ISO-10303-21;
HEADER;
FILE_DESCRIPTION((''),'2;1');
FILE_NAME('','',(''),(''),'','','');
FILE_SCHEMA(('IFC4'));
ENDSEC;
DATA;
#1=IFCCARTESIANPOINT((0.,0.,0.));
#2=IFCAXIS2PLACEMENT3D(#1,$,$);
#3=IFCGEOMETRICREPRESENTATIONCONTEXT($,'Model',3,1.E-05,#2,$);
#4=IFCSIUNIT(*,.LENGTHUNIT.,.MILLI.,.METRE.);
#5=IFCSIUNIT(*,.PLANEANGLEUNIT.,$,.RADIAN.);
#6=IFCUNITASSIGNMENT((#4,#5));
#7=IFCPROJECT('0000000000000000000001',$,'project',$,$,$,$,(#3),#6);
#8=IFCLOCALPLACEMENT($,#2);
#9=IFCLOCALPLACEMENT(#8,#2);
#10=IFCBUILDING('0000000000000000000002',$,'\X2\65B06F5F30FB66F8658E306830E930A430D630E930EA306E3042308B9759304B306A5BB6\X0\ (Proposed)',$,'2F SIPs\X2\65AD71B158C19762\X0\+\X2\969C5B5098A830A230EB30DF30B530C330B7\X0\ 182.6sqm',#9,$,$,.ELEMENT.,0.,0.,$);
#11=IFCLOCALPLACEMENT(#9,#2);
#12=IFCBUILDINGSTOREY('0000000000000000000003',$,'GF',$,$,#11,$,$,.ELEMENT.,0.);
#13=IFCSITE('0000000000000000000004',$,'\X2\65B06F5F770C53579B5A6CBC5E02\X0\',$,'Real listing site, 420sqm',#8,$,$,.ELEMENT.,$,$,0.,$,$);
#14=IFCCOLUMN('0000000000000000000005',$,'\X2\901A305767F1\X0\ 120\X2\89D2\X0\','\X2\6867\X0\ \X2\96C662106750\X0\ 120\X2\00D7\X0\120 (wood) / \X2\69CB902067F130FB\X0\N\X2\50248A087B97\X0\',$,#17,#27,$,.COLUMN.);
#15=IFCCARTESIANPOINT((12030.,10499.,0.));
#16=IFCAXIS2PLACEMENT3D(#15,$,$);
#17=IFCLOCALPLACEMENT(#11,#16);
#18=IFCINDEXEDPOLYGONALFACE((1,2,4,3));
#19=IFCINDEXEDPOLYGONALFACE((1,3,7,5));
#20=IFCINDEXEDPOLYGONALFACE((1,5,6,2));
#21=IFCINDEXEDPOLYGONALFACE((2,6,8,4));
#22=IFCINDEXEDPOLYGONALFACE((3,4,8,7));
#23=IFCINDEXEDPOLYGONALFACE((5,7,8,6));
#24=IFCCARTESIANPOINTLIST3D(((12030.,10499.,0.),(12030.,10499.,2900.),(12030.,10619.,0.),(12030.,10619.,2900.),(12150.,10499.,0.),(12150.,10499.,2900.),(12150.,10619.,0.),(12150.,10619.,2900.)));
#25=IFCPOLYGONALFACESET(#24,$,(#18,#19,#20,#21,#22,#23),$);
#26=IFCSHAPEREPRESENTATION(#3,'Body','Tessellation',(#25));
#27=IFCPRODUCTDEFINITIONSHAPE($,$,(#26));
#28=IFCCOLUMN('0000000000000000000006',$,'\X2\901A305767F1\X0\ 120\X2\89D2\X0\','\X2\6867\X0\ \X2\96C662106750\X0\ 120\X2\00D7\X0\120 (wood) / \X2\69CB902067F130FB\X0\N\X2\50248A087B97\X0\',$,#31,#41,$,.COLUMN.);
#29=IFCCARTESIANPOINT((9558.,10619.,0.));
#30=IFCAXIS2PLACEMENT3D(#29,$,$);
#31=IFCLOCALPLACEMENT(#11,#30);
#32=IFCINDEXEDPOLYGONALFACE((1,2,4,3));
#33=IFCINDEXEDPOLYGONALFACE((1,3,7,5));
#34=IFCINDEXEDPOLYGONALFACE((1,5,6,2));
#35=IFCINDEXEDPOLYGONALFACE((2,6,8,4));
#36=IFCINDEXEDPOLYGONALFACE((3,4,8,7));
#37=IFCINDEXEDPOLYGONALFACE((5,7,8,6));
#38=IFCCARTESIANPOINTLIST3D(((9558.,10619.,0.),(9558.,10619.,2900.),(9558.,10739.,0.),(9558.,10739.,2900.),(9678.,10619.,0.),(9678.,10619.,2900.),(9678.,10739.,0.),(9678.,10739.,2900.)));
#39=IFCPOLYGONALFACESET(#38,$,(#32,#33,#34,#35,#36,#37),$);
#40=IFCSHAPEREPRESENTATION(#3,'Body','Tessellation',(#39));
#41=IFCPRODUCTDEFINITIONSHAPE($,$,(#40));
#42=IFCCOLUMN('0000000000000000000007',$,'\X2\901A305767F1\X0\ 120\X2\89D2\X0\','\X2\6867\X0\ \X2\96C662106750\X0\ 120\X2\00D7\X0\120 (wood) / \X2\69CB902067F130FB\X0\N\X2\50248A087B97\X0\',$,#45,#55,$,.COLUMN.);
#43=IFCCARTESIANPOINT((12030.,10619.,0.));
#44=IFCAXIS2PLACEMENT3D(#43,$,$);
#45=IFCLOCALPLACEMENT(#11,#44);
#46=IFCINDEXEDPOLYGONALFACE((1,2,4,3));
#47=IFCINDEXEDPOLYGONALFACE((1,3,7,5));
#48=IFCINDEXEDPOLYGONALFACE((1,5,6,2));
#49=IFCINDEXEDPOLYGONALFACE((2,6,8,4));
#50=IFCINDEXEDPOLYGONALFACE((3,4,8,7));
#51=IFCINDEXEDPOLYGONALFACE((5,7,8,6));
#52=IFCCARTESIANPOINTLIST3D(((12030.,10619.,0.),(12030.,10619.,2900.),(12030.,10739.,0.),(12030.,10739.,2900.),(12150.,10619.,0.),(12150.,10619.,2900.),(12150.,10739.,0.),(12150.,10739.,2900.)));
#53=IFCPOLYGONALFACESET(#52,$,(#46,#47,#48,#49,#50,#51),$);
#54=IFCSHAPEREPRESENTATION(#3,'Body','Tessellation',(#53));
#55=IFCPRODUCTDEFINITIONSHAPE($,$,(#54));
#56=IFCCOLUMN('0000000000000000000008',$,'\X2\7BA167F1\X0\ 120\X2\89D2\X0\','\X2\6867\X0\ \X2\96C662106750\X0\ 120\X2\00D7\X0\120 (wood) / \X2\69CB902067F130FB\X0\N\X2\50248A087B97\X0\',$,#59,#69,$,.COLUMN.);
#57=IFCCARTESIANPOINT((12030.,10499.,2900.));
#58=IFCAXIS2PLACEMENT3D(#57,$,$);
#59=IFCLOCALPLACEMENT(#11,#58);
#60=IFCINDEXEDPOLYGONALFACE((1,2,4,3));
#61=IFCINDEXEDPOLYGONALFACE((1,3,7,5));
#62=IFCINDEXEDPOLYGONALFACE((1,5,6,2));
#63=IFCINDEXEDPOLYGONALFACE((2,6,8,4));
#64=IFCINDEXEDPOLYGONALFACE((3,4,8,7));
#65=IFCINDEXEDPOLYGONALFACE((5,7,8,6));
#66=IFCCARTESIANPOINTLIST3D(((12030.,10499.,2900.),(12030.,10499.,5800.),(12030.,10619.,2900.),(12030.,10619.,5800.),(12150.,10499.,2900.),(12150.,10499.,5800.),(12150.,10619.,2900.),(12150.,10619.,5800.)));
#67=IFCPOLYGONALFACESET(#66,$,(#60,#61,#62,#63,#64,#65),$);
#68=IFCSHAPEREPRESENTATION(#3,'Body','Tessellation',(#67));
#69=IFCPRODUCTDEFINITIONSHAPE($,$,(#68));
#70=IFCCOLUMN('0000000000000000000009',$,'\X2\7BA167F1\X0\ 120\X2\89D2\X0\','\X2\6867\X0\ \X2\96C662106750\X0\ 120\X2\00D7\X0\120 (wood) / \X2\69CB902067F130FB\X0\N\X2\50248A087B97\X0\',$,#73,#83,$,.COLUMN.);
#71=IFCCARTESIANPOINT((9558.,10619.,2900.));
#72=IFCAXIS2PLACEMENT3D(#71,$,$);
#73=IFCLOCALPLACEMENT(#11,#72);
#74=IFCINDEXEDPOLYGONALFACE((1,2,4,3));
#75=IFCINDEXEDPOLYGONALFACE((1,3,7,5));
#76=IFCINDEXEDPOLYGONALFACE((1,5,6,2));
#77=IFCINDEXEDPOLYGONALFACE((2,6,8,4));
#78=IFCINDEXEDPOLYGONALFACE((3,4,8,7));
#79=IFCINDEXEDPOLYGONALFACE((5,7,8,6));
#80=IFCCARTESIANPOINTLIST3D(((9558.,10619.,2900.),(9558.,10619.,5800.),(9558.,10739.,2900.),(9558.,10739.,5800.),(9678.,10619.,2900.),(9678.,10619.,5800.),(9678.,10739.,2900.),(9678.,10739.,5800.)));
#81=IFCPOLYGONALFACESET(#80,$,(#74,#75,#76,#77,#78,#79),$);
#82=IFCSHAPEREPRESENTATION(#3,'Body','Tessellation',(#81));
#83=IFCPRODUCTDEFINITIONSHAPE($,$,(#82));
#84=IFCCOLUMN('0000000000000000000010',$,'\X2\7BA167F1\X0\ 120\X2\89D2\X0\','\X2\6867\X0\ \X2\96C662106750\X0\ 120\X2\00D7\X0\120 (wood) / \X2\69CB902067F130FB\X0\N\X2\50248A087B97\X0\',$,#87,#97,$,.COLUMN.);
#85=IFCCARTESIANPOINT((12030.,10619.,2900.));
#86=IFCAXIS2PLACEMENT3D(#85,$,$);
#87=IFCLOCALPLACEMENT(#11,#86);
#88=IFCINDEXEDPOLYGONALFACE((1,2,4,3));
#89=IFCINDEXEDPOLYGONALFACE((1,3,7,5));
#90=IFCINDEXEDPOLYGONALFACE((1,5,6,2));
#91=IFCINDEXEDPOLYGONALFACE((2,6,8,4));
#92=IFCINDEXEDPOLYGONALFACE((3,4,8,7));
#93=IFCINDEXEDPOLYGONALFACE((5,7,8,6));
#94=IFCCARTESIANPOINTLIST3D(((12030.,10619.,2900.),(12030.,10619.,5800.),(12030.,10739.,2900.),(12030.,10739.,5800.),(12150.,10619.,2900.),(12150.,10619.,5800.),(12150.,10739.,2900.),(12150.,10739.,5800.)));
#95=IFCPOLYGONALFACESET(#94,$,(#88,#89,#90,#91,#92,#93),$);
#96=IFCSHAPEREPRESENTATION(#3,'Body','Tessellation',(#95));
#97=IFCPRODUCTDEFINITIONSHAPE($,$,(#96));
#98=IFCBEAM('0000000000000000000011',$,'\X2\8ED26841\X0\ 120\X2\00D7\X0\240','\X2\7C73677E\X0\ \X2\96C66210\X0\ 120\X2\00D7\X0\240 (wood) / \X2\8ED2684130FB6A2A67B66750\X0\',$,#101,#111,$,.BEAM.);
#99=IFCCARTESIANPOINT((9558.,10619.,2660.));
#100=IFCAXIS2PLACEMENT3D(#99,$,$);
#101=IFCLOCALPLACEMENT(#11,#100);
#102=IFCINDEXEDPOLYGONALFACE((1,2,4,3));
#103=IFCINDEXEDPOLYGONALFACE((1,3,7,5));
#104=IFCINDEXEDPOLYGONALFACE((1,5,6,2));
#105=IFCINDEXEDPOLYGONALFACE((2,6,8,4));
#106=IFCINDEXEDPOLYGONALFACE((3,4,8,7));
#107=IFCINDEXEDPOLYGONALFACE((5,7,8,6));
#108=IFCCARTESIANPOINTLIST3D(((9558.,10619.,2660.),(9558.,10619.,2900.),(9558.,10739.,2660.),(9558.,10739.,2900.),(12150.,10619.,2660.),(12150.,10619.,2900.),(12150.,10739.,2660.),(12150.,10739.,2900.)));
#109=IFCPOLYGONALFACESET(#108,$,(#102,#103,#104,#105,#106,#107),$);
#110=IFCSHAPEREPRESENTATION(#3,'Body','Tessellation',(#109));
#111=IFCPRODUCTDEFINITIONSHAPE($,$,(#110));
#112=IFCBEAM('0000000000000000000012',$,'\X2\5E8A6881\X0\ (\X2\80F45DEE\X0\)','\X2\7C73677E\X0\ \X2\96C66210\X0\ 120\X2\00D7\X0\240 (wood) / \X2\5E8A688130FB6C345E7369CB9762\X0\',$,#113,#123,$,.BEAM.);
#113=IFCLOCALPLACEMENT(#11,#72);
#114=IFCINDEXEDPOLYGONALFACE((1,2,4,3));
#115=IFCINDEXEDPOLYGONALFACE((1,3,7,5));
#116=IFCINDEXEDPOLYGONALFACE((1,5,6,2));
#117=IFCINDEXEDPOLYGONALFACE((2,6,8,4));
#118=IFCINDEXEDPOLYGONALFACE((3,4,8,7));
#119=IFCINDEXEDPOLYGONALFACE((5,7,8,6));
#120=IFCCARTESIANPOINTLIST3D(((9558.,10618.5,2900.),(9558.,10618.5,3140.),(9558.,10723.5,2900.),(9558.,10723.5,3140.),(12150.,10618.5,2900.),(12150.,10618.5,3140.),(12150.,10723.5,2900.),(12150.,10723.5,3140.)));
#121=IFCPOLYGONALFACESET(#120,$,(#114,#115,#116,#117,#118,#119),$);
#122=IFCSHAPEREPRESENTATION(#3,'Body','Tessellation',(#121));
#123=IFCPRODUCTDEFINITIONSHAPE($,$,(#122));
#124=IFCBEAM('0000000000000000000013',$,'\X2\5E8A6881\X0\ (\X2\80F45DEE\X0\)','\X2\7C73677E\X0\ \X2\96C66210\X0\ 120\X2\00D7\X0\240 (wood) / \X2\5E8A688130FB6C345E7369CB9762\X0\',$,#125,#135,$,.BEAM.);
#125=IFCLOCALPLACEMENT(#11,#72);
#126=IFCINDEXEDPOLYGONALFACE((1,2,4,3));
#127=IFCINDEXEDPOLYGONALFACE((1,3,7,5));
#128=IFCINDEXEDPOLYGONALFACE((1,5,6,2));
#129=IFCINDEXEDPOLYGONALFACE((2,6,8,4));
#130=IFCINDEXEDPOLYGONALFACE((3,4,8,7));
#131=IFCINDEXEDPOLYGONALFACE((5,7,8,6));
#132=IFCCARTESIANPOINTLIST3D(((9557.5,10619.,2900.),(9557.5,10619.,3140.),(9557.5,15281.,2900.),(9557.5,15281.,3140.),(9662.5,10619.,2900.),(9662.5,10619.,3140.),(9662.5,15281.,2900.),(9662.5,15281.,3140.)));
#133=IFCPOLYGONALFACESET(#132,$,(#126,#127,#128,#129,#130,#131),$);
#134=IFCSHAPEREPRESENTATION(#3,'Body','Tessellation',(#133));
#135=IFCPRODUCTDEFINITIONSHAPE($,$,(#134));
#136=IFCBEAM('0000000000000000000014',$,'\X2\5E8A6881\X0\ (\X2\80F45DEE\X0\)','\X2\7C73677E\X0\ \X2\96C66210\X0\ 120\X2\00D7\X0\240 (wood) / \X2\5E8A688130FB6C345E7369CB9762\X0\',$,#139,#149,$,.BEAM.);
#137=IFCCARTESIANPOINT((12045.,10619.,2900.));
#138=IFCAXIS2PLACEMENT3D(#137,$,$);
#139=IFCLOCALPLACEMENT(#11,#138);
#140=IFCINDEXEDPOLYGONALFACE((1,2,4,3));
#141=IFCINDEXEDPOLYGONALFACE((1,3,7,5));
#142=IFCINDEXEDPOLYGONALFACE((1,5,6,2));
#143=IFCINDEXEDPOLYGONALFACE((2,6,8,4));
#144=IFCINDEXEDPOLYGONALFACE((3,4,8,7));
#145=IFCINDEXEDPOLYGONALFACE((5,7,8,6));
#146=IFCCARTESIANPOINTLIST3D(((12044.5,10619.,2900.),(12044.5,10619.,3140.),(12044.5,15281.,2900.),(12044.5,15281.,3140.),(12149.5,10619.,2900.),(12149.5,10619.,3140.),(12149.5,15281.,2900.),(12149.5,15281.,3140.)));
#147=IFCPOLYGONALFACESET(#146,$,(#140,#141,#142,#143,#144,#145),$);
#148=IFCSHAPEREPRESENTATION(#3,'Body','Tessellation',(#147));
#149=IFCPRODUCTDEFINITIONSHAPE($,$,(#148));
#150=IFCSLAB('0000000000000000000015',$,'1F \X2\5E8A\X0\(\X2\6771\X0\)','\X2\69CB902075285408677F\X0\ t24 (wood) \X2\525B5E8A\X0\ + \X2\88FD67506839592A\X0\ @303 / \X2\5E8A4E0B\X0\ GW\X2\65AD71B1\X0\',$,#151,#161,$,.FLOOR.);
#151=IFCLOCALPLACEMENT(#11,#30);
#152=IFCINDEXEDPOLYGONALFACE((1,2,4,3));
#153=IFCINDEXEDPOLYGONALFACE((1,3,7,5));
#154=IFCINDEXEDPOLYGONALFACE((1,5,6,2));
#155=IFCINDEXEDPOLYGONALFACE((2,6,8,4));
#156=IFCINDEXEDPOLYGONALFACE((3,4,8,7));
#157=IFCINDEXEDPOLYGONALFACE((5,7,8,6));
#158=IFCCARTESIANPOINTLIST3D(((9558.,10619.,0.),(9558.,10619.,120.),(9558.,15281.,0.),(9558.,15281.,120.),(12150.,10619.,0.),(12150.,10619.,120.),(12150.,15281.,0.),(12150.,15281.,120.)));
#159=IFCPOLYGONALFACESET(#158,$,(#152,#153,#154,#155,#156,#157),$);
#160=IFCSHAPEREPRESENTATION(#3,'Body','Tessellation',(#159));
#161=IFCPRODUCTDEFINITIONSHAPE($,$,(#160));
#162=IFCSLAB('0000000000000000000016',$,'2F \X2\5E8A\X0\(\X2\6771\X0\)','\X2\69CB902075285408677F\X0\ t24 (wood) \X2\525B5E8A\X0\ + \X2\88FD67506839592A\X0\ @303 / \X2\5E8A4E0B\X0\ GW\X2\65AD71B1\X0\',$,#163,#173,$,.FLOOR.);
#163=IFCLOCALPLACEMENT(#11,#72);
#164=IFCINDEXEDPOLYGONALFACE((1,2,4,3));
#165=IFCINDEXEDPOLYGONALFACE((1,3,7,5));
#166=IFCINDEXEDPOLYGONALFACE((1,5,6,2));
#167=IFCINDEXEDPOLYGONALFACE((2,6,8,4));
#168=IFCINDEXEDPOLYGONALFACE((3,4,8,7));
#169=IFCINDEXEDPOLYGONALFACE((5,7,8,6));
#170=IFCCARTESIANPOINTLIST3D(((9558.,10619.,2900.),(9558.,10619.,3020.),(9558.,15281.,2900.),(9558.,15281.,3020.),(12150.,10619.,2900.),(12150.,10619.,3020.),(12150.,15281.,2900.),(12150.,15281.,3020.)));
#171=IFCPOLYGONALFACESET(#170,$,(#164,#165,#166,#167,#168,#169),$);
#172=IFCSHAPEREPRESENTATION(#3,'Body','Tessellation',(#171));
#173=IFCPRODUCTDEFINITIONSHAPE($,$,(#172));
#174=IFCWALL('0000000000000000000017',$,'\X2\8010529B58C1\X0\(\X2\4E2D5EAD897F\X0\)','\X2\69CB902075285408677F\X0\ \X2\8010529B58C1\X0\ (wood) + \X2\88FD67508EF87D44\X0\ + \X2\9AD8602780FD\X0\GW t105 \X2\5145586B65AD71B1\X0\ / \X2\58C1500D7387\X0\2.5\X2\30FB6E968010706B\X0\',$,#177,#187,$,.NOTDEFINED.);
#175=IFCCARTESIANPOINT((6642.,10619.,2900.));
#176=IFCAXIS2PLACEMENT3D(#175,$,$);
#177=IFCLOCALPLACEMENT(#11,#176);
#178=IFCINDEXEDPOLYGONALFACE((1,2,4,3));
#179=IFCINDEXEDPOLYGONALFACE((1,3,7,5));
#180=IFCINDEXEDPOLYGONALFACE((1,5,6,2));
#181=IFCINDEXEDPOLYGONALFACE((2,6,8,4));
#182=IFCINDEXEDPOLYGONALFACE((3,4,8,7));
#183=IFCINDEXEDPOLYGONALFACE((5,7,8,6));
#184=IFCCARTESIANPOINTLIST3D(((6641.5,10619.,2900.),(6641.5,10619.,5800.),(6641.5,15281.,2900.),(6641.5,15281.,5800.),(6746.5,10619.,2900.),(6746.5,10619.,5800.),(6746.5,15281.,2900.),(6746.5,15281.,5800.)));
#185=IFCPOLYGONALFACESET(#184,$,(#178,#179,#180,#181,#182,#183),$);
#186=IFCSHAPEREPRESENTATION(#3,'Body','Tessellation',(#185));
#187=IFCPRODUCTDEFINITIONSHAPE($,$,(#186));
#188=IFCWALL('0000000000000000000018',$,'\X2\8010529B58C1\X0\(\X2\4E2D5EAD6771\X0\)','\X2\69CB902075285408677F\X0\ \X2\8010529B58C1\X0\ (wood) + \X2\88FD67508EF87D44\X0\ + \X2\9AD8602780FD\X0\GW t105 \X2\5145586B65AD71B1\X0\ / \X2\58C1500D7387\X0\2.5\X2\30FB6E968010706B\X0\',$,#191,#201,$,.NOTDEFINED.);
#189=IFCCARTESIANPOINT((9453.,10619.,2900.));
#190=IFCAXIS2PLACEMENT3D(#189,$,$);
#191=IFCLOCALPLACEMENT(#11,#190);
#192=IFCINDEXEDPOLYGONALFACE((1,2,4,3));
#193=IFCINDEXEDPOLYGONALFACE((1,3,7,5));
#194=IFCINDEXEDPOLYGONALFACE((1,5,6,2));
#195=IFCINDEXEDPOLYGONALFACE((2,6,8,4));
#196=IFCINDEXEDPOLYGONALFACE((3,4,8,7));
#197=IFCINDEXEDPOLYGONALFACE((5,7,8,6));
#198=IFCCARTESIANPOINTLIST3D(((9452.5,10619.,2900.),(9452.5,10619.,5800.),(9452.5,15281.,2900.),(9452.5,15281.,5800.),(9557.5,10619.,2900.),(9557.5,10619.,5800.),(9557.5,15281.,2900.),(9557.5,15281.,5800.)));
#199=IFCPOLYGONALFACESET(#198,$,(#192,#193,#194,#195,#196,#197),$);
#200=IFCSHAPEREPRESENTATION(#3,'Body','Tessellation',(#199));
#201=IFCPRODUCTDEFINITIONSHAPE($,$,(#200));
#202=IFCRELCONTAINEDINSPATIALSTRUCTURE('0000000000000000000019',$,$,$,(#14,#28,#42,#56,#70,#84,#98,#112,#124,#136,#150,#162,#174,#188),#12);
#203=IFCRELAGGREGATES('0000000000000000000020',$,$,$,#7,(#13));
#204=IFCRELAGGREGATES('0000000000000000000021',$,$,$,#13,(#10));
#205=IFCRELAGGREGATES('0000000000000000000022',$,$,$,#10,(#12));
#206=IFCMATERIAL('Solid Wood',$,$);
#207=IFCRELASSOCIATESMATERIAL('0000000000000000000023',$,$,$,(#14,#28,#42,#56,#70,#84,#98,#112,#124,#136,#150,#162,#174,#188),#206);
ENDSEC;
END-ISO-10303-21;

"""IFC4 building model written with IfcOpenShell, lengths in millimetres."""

from ifc_helpers import new_model, si_unit, frame, frame_2d, origin, place, context, project, spatial, rectangle, extrude, material, element, save


model = new_model("IFC4")

# Units and contexts
model_context = context("Model", 3, precision=1e-05, world=origin())
ifc_project = project(units=[si_unit("LENGTHUNIT", "METRE", prefix="MILLI"), si_unit("PLANEANGLEUNIT", "RADIAN")], contexts=[model_context])

# Site, building, storey
site_placement = place(None, origin())
site = spatial("IfcSite", under=ifc_project, at=site_placement, Name="新潟県南魚沼市", ObjectType="Real listing site, 420sqm", CompositionType="ELEMENT", RefElevation=0.0)
building_placement = place(site_placement, origin())
building = spatial("IfcBuilding", under=site, at=building_placement, Name="新潟・書斎とライブラリのある静かな家 (Proposed)", ObjectType="2F SIPs断熱壁面+障子風アルミサッシ 182.6sqm", CompositionType="ELEMENT", ElevationOfRefHeight=0.0, ElevationOfTerrain=0.0)
storey_placement = place(building_placement, origin())
storey = spatial("IfcBuildingStorey", under=building, at=storey_placement, Name="GF", CompositionType="ELEMENT", Elevation=0.0)

# Columns
ifc_material_1 = material(Name="Solid Wood")
column_1_placement = place(storey_placement, frame((12030.0, 10499.0, 0.0)))
element("IfcColumn", 1, at=column_1_placement, inside=storey, material=ifc_material_1, Name="通し柱 120角", Description="桧 集成材 120×120 (wood) / 構造柱・N値計算", PredefinedType="COLUMN", context=model_context, shape_type="SweptSolid", body=[
    extrude(rectangle(XDim=120.0, YDim=120.0, at=frame_2d((60.0, 60.0))), frame((12030.0, 10499.0, 0.0)), (0.0, 0.0, 1.0), 2900.0),
])
column_2_placement = place(storey_placement, frame((9558.0, 10619.0, 0.0)))
element("IfcColumn", 2, at=column_2_placement, inside=storey, material=ifc_material_1, Name="通し柱 120角", Description="桧 集成材 120×120 (wood) / 構造柱・N値計算", PredefinedType="COLUMN", context=model_context, shape_type="SweptSolid", body=[
    extrude(rectangle(XDim=120.0, YDim=120.0, at=frame_2d((60.0, 60.0))), frame((9558.0, 10619.0, 0.0)), (0.0, 0.0, 1.0), 2900.0),
])
column_3_placement = place(storey_placement, frame((12030.0, 10619.0, 0.0)))
element("IfcColumn", 3, at=column_3_placement, inside=storey, material=ifc_material_1, Name="通し柱 120角", Description="桧 集成材 120×120 (wood) / 構造柱・N値計算", PredefinedType="COLUMN", context=model_context, shape_type="SweptSolid", body=[
    extrude(rectangle(XDim=120.0, YDim=120.0, at=frame_2d((60.0, 60.0))), frame((12030.0, 10619.0, 0.0)), (0.0, 0.0, 1.0), 2900.0),
])
column_4_placement = place(storey_placement, frame((12030.0, 10499.0, 2900.0)))
element("IfcColumn", 4, at=column_4_placement, inside=storey, material=ifc_material_1, Name="管柱 120角", Description="桧 集成材 120×120 (wood) / 構造柱・N値計算", PredefinedType="COLUMN", context=model_context, shape_type="SweptSolid", body=[
    extrude(rectangle(XDim=120.0, YDim=120.0, at=frame_2d((60.0, 60.0))), frame((12030.0, 10499.0, 2900.0)), (0.0, 0.0, 1.0), 2900.0),
])
column_5_placement = place(storey_placement, frame((9558.0, 10619.0, 2900.0)))
element("IfcColumn", 5, at=column_5_placement, inside=storey, material=ifc_material_1, Name="管柱 120角", Description="桧 集成材 120×120 (wood) / 構造柱・N値計算", PredefinedType="COLUMN", context=model_context, shape_type="SweptSolid", body=[
    extrude(rectangle(XDim=120.0, YDim=120.0, at=frame_2d((60.0, 60.0))), frame((9558.0, 10619.0, 2900.0)), (0.0, 0.0, 1.0), 2900.0),
])
column_6_placement = place(storey_placement, frame((12030.0, 10619.0, 2900.0)))
element("IfcColumn", 6, at=column_6_placement, inside=storey, material=ifc_material_1, Name="管柱 120角", Description="桧 集成材 120×120 (wood) / 構造柱・N値計算", PredefinedType="COLUMN", context=model_context, shape_type="SweptSolid", body=[
    extrude(rectangle(XDim=120.0, YDim=120.0, at=frame_2d((60.0, 60.0))), frame((12030.0, 10619.0, 2900.0)), (0.0, 0.0, 1.0), 2900.0),
])

# Beams
beam_1_placement = place(storey_placement, frame((9558.0, 10619.0, 2660.0)))
element("IfcBeam", 7, at=beam_1_placement, inside=storey, material=ifc_material_1, Name="軒桁 120×240", Description="米松 集成 120×240 (wood) / 軒桁・横架材", PredefinedType="BEAM", context=model_context, shape_type="SweptSolid", body=[
    extrude(rectangle(XDim=2592.0, YDim=120.0, at=frame_2d((1296.0, 60.0))), frame((9558.0, 10619.0, 2660.0)), (0.0, 0.0, 1.0), 240.0),
])
beam_2_placement = place(storey_placement, frame((9558.0, 10619.0, 2900.0)))
element("IfcBeam", 8, at=beam_2_placement, inside=storey, material=ifc_material_1, Name="床梁 (胴差)", Description="米松 集成 120×240 (wood) / 床梁・水平構面", PredefinedType="BEAM", context=model_context, shape_type="SweptSolid", body=[
    extrude(rectangle(XDim=2592.0, YDim=105.0, at=frame_2d((1296.0, 52.0))), frame((9558.0, 10619.0, 2900.0)), (0.0, 0.0, 1.0), 240.0),
])
beam_3_placement = place(storey_placement, frame((9558.0, 10619.0, 2900.0)))
element("IfcBeam", 9, at=beam_3_placement, inside=storey, material=ifc_material_1, Name="床梁 (胴差)", Description="米松 集成 120×240 (wood) / 床梁・水平構面", PredefinedType="BEAM", context=model_context, shape_type="SweptSolid", body=[
    extrude(rectangle(XDim=105.0, YDim=4662.0, at=frame_2d((52.0, 2331.0))), frame((9558.0, 10619.0, 2900.0)), (0.0, 0.0, 1.0), 240.0),
])
beam_4_placement = place(storey_placement, frame((12045.0, 10619.0, 2900.0)))
element("IfcBeam", 10, at=beam_4_placement, inside=storey, material=ifc_material_1, Name="床梁 (胴差)", Description="米松 集成 120×240 (wood) / 床梁・水平構面", PredefinedType="BEAM", context=model_context, shape_type="SweptSolid", body=[
    extrude(rectangle(XDim=105.0, YDim=4662.0, at=frame_2d((52.0, 2331.0))), frame((12045.0, 10619.0, 2900.0)), (0.0, 0.0, 1.0), 240.0),
])

# Slabs
slab_1_placement = place(storey_placement, frame((9558.0, 10619.0, 0.0)))
element("IfcSlab", 11, at=slab_1_placement, inside=storey, material=ifc_material_1, Name="1F 床(東)", Description="構造用合板 t24 (wood) 剛床 + 製材根太 @303 / 床下 GW断熱", PredefinedType="FLOOR", context=model_context, shape_type="SweptSolid", body=[
    extrude(rectangle(XDim=2592.0, YDim=4662.0, at=frame_2d((1296.0, 2331.0))), frame((9558.0, 10619.0, 0.0)), (0.0, 0.0, 1.0), 120.0),
])
slab_2_placement = place(storey_placement, frame((9558.0, 10619.0, 2900.0)))
element("IfcSlab", 12, at=slab_2_placement, inside=storey, material=ifc_material_1, Name="2F 床(東)", Description="構造用合板 t24 (wood) 剛床 + 製材根太 @303 / 床下 GW断熱", PredefinedType="FLOOR", context=model_context, shape_type="SweptSolid", body=[
    extrude(rectangle(XDim=2592.0, YDim=4662.0, at=frame_2d((1296.0, 2331.0))), frame((9558.0, 10619.0, 2900.0)), (0.0, 0.0, 1.0), 120.0),
])

# Walls
wall_1_placement = place(storey_placement, frame((6642.0, 10619.0, 2900.0)))
element("IfcWall", 13, at=wall_1_placement, inside=storey, material=ifc_material_1, Name="耐力壁(中庭西)", Description="構造用合板 耐力壁 (wood) + 製材軸組 + 高性能GW t105 充填断熱 / 壁倍率2.5・準耐火", PredefinedType="NOTDEFINED", context=model_context, shape_type="SweptSolid", body=[
    extrude(rectangle(XDim=105.0, YDim=4662.0, at=frame_2d((52.0, 2331.0))), frame((6642.0, 10619.0, 2900.0)), (0.0, 0.0, 1.0), 2900.0),
])
wall_2_placement = place(storey_placement, frame((9453.0, 10619.0, 2900.0)))
element("IfcWall", 14, at=wall_2_placement, inside=storey, material=ifc_material_1, Name="耐力壁(中庭東)", Description="構造用合板 耐力壁 (wood) + 製材軸組 + 高性能GW t105 充填断熱 / 壁倍率2.5・準耐火", PredefinedType="NOTDEFINED", context=model_context, shape_type="SweptSolid", body=[
    extrude(rectangle(XDim=105.0, YDim=4662.0, at=frame_2d((52.0, 2331.0))), frame((9453.0, 10619.0, 2900.0)), (0.0, 0.0, 1.0), 2900.0),
])

save(model, "model.ifc")
